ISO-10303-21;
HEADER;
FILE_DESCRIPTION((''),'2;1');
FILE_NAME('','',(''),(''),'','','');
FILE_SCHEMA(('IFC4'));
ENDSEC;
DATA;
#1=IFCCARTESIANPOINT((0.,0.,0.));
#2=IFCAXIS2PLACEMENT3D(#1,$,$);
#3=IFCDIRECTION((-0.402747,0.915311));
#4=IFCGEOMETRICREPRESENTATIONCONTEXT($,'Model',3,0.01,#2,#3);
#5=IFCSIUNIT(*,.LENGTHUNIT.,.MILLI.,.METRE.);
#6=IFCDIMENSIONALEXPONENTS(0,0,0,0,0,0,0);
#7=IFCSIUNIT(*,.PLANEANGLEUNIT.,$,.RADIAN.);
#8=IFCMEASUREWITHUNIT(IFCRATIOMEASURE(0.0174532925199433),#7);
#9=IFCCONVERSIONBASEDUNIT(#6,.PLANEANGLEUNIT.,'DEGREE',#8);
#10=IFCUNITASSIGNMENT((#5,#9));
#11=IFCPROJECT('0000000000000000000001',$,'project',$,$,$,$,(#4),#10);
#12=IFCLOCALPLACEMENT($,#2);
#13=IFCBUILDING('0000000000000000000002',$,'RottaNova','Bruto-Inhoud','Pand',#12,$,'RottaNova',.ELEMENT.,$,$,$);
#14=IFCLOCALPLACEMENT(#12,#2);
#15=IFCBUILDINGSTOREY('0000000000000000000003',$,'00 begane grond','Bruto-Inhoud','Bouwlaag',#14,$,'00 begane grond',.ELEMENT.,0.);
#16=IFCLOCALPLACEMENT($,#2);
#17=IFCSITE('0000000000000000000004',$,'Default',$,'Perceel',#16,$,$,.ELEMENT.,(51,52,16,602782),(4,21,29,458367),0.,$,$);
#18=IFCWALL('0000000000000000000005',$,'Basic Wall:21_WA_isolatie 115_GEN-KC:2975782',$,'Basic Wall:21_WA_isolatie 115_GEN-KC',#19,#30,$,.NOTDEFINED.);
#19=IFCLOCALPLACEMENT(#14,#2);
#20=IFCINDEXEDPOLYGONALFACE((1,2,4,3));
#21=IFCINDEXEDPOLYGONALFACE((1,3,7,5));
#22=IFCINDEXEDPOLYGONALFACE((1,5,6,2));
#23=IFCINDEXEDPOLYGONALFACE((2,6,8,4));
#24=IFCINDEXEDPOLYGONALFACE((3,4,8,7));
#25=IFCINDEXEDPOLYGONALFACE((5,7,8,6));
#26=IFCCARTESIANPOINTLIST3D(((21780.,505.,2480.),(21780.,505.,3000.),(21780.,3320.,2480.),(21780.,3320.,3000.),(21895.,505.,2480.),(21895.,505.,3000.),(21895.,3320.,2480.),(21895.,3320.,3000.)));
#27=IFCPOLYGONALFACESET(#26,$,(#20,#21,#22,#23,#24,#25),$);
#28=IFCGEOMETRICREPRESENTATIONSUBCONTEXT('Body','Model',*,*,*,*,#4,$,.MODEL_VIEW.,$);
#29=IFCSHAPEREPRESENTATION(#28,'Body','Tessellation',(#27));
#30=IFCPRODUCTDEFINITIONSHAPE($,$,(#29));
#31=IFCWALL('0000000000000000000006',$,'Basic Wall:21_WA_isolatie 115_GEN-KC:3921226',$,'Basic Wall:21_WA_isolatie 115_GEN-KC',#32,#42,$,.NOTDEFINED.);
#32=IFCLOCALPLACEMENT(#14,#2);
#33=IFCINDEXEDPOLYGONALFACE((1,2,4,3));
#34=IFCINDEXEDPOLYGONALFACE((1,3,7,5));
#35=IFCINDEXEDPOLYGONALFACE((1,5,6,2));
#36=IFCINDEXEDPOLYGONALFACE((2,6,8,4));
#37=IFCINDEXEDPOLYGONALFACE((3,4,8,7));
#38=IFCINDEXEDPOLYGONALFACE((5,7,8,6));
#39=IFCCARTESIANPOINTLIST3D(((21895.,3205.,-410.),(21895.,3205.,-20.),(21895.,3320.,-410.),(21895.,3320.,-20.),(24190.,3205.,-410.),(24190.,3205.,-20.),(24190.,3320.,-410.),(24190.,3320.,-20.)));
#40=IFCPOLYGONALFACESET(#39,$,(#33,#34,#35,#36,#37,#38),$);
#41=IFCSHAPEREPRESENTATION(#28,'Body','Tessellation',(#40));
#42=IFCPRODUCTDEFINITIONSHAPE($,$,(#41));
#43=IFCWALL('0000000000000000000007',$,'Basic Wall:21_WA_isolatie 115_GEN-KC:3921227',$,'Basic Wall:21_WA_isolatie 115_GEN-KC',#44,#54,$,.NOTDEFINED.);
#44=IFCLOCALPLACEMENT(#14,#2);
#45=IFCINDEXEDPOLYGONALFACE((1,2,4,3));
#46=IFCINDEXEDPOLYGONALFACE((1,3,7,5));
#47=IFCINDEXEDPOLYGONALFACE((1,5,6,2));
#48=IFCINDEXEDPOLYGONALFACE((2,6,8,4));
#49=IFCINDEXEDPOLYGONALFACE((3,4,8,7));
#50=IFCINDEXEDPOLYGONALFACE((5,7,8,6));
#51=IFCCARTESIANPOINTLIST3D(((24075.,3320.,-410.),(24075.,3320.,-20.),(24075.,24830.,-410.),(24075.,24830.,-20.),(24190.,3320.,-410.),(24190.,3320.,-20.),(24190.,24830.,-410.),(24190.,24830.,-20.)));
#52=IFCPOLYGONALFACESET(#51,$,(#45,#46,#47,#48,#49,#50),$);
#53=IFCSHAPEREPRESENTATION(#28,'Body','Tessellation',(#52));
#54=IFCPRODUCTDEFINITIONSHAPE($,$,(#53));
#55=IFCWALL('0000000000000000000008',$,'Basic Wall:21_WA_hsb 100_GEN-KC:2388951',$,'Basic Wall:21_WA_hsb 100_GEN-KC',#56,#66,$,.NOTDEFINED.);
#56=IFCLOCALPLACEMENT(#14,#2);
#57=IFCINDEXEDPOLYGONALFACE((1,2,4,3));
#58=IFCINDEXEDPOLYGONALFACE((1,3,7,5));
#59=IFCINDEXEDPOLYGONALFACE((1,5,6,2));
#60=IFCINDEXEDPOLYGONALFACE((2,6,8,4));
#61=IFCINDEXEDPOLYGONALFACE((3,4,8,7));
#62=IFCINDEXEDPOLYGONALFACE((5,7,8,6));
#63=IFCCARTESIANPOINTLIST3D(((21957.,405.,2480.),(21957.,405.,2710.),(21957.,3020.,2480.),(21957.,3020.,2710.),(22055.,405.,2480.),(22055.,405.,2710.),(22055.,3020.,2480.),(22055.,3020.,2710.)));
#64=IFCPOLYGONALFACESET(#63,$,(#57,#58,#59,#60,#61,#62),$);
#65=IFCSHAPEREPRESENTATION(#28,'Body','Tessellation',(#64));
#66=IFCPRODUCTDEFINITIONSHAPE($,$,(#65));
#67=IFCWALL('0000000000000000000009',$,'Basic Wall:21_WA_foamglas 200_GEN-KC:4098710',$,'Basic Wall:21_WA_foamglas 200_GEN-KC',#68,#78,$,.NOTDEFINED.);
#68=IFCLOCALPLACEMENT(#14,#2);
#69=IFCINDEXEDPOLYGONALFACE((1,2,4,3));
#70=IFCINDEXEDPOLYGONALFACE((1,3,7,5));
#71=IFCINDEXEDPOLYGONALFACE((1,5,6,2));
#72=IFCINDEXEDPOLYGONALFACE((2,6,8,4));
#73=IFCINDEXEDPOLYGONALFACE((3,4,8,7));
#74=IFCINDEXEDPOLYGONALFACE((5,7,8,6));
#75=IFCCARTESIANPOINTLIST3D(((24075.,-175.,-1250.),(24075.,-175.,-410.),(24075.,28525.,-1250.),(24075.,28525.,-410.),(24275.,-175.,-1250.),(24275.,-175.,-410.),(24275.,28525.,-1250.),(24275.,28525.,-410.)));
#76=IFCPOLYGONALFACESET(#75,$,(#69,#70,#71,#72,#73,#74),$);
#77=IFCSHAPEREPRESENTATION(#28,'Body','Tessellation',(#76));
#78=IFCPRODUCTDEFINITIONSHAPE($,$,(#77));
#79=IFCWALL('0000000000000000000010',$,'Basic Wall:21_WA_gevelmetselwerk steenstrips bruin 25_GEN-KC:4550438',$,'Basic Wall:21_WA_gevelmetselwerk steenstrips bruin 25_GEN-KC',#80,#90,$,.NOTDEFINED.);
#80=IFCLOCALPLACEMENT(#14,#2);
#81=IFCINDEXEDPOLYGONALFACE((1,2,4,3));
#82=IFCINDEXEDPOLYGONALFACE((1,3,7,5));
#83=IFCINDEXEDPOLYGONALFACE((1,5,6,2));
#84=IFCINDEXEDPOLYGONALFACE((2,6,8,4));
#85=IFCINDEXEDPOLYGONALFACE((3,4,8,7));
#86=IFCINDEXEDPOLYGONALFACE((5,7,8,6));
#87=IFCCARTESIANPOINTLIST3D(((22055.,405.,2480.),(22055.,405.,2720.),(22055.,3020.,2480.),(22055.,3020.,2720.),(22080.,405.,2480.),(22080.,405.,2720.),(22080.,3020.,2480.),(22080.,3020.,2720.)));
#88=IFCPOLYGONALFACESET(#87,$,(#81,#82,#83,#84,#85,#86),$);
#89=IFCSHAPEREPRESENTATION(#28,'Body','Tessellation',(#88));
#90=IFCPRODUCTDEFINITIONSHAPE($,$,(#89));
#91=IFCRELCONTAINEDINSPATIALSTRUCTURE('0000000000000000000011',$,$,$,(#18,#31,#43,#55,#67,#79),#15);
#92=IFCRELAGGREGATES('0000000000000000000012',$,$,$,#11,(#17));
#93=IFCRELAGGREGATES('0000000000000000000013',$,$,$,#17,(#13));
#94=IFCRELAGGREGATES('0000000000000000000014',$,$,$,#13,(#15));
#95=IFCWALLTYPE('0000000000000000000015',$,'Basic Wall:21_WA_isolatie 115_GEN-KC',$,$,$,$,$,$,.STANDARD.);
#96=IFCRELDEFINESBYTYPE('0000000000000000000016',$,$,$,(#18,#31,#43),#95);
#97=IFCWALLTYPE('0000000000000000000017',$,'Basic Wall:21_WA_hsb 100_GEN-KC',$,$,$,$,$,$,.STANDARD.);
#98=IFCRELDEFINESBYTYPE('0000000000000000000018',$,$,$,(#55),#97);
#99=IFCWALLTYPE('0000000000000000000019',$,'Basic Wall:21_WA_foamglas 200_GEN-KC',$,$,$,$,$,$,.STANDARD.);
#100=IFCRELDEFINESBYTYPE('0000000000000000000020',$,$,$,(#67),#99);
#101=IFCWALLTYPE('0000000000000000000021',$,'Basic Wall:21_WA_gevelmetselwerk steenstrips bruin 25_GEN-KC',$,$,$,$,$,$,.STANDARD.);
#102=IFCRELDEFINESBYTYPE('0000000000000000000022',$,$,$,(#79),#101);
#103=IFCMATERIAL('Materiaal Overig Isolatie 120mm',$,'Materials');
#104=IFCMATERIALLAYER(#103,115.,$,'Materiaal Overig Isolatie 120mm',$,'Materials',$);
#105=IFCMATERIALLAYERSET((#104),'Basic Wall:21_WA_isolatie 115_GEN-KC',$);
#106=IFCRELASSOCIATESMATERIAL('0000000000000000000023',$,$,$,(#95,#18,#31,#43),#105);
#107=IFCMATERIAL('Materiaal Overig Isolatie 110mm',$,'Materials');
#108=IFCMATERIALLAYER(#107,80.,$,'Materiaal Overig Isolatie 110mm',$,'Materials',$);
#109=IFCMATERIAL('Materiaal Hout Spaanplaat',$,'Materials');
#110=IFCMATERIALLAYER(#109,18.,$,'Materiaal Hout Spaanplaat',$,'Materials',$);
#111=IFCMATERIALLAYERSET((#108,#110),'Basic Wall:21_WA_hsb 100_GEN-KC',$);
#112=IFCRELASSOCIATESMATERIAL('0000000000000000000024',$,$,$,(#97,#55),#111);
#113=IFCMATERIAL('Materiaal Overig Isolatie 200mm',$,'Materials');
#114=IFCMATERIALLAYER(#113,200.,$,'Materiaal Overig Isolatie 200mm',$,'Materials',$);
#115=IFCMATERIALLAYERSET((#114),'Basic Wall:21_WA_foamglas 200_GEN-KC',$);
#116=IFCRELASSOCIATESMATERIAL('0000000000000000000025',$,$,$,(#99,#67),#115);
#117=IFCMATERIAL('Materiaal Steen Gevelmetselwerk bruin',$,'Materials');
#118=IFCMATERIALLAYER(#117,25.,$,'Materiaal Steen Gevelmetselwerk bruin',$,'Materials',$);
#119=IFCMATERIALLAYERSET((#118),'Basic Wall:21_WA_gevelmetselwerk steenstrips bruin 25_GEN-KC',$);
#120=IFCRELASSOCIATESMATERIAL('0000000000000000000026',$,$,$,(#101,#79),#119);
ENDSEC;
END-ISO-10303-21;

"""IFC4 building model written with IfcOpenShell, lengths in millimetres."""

from ifc_helpers import new_model, entity, si_unit, converted_unit, direction, frame, frame_2d, origin, place, context, subcontext, project, spatial, rectangle, extrude, material, layer, layer_set, type_object, element, save


model = new_model("IFC4")

# Units and contexts
model_context = context("Model", 3, precision=0.01, world=origin(), true_north=direction((-0.402747, 0.915311)))
body_context = subcontext(model_context, "Body", "Model", "MODEL_VIEW")
ifc_project = project(units=[si_unit("LENGTHUNIT", "METRE", prefix="MILLI"), converted_unit("PLANEANGLEUNIT", "DEGREE", entity("IfcRatioMeasure", 0.0174532925199433), si_unit("PLANEANGLEUNIT", "RADIAN"), dimensions=[0, 0, 0, 0, 0, 0, 0])], contexts=[model_context])

# Site, building, storey
site_placement = place(None, origin())
site = spatial("IfcSite", under=ifc_project, at=site_placement, Name="Default", ObjectType="Perceel", CompositionType="ELEMENT", RefLatitude=(51, 52, 16, 602782), RefLongitude=(4, 21, 29, 458367), RefElevation=0.0)
building_placement = place(None, origin())
building = spatial("IfcBuilding", under=site, at=building_placement, Name="RottaNova", Description="Bruto-Inhoud", ObjectType="Pand", LongName="RottaNova", CompositionType="ELEMENT")
storey_placement = place(building_placement, origin())
storey = spatial("IfcBuildingStorey", under=building, at=storey_placement, Name="00 begane grond", Description="Bruto-Inhoud", ObjectType="Bouwlaag", LongName="00 begane grond", CompositionType="ELEMENT", Elevation=0.0)

# Walls
ifc_material_1 = material(Name="Materiaal Steen Gevelmetselwerk bruin", Category="Materials")
ifc_material_2 = material(Name="Materiaal Overig Isolatie 120mm", Category="Materials")
ifc_layer_1 = layer(ifc_material_2, 115.0, Name="Materiaal Overig Isolatie 120mm", Category="Materials")
ifc_layer_set_1 = layer_set([ifc_layer_1], Name="Basic Wall:21_WA_isolatie 115_GEN-KC")
wall_type_1 = type_object("IfcWallType", Name="Basic Wall:21_WA_isolatie 115_GEN-KC", PredefinedType="STANDARD", material=ifc_layer_set_1)
wall_1_placement = place(storey_placement, frame((21837.5, 3320.0, 2480.0), z_axis=(0.0, 0.0, 1.0), x_axis=(0.0, -1.0, 0.0)))
element("IfcWall", 1, at=wall_1_placement, inside=storey, type_object=wall_type_1, material=ifc_layer_set_1, Name="Basic Wall:21_WA_isolatie 115_GEN-KC:2975782", ObjectType="Basic Wall:21_WA_isolatie 115_GEN-KC", PredefinedType="NOTDEFINED", context=body_context, shape_type="SweptSolid", body=[
    extrude(rectangle(XDim=2815.0, YDim=115.0, at=frame_2d((1407.5, 0.0), x_axis=(-1.0, 0.0))), origin(), (0.0, 0.0, 1.0), 520.0),
])
wall_2_placement = place(storey_placement, frame((21895.0, 3262.5, -410.0)))
element("IfcWall", 2, at=wall_2_placement, inside=storey, type_object=wall_type_1, material=ifc_layer_set_1, Name="Basic Wall:21_WA_isolatie 115_GEN-KC:3921226", ObjectType="Basic Wall:21_WA_isolatie 115_GEN-KC", PredefinedType="NOTDEFINED", context=body_context, shape_type="SweptSolid", body=[
    extrude(rectangle(XDim=2295.0, YDim=115.0, at=frame_2d((1147.5, 0.0), x_axis=(-1.0, 0.0))), origin(), (0.0, 0.0, 1.0), 390.0),
])
wall_3_placement = place(storey_placement, frame((24132.5, 3320.0, -410.0), z_axis=(0.0, 0.0, 1.0), x_axis=(0.0, 1.0, 0.0)))
element("IfcWall", 3, at=wall_3_placement, inside=storey, type_object=wall_type_1, material=ifc_layer_set_1, Name="Basic Wall:21_WA_isolatie 115_GEN-KC:3921227", ObjectType="Basic Wall:21_WA_isolatie 115_GEN-KC", PredefinedType="NOTDEFINED", context=body_context, shape_type="SweptSolid", body=[
    extrude(rectangle(XDim=21510.0, YDim=115.0, at=frame_2d((10755.0, 0.0), x_axis=(-1.0, 0.0))), origin(), (0.0, 0.0, 1.0), 390.0),
])
ifc_material_3 = material(Name="Materiaal Overig Isolatie 110mm", Category="Materials")
ifc_layer_2 = layer(ifc_material_3, 80.0, Name="Materiaal Overig Isolatie 110mm", Category="Materials")
ifc_material_4 = material(Name="Materiaal Hout Spaanplaat", Category="Materials")
ifc_layer_3 = layer(ifc_material_4, 18.0, Name="Materiaal Hout Spaanplaat", Category="Materials")
ifc_layer_set_2 = layer_set([ifc_layer_2, ifc_layer_3], Name="Basic Wall:21_WA_hsb 100_GEN-KC")
wall_type_2 = type_object("IfcWallType", Name="Basic Wall:21_WA_hsb 100_GEN-KC", PredefinedType="STANDARD", material=ifc_layer_set_2)
wall_4_placement = place(storey_placement, frame((22006.0, 3020.0, 2480.0), z_axis=(0.0, 0.0, 1.0), x_axis=(0.0, -1.0, 0.0)))
element("IfcWall", 4, at=wall_4_placement, inside=storey, type_object=wall_type_2, material=ifc_layer_set_2, Name="Basic Wall:21_WA_hsb 100_GEN-KC:2388951", ObjectType="Basic Wall:21_WA_hsb 100_GEN-KC", PredefinedType="NOTDEFINED", context=body_context, shape_type="SweptSolid", body=[
    extrude(rectangle(XDim=2615.0, YDim=98.0, at=frame_2d((1307.5, 0.0), x_axis=(-1.0, 0.0))), origin(), (0.0, 0.0, 1.0), 230.0),
])
ifc_material_5 = material(Name="Materiaal Overig Isolatie 200mm", Category="Materials")
ifc_layer_4 = layer(ifc_material_5, 200.0, Name="Materiaal Overig Isolatie 200mm", Category="Materials")
ifc_layer_set_3 = layer_set([ifc_layer_4], Name="Basic Wall:21_WA_foamglas 200_GEN-KC")
wall_type_3 = type_object("IfcWallType", Name="Basic Wall:21_WA_foamglas 200_GEN-KC", PredefinedType="STANDARD", material=ifc_layer_set_3)
wall_5_placement = place(storey_placement, frame((24175.0, -175.0, -1250.0), z_axis=(0.0, 0.0, 1.0), x_axis=(0.0, 1.0, 0.0)))
element("IfcWall", 5, at=wall_5_placement, inside=storey, type_object=wall_type_3, material=ifc_layer_set_3, Name="Basic Wall:21_WA_foamglas 200_GEN-KC:4098710", ObjectType="Basic Wall:21_WA_foamglas 200_GEN-KC", PredefinedType="NOTDEFINED", context=body_context, shape_type="SweptSolid", body=[
    extrude(rectangle(XDim=28700.0, YDim=200.0, at=frame_2d((14350.0, 0.0), x_axis=(-1.0, 0.0))), origin(), (0.0, 0.0, 1.0), 840.0),
])
ifc_layer_5 = layer(ifc_material_1, 25.0, Name="Materiaal Steen Gevelmetselwerk bruin", Category="Materials")
ifc_layer_set_4 = layer_set([ifc_layer_5], Name="Basic Wall:21_WA_gevelmetselwerk steenstrips bruin 25_GEN-KC")
wall_type_4 = type_object("IfcWallType", Name="Basic Wall:21_WA_gevelmetselwerk steenstrips bruin 25_GEN-KC", PredefinedType="STANDARD", material=ifc_layer_set_4)
wall_6_placement = place(storey_placement, frame((22067.5, 405.0, 2480.0), z_axis=(0.0, 0.0, 1.0), x_axis=(0.0, 1.0, 0.0)))
element("IfcWall", 6, at=wall_6_placement, inside=storey, type_object=wall_type_4, material=ifc_layer_set_4, Name="Basic Wall:21_WA_gevelmetselwerk steenstrips bruin 25_GEN-KC:4550438", ObjectType="Basic Wall:21_WA_gevelmetselwerk steenstrips bruin 25_GEN-KC", PredefinedType="NOTDEFINED", context=body_context, shape_type="SweptSolid", body=[
    extrude(rectangle(XDim=2615.0, YDim=25.0, at=frame_2d((1307.5, 0.0), x_axis=(-1.0, 0.0))), origin(), (0.0, 0.0, 1.0), 240.0),
])

save(model, "model.ifc")
